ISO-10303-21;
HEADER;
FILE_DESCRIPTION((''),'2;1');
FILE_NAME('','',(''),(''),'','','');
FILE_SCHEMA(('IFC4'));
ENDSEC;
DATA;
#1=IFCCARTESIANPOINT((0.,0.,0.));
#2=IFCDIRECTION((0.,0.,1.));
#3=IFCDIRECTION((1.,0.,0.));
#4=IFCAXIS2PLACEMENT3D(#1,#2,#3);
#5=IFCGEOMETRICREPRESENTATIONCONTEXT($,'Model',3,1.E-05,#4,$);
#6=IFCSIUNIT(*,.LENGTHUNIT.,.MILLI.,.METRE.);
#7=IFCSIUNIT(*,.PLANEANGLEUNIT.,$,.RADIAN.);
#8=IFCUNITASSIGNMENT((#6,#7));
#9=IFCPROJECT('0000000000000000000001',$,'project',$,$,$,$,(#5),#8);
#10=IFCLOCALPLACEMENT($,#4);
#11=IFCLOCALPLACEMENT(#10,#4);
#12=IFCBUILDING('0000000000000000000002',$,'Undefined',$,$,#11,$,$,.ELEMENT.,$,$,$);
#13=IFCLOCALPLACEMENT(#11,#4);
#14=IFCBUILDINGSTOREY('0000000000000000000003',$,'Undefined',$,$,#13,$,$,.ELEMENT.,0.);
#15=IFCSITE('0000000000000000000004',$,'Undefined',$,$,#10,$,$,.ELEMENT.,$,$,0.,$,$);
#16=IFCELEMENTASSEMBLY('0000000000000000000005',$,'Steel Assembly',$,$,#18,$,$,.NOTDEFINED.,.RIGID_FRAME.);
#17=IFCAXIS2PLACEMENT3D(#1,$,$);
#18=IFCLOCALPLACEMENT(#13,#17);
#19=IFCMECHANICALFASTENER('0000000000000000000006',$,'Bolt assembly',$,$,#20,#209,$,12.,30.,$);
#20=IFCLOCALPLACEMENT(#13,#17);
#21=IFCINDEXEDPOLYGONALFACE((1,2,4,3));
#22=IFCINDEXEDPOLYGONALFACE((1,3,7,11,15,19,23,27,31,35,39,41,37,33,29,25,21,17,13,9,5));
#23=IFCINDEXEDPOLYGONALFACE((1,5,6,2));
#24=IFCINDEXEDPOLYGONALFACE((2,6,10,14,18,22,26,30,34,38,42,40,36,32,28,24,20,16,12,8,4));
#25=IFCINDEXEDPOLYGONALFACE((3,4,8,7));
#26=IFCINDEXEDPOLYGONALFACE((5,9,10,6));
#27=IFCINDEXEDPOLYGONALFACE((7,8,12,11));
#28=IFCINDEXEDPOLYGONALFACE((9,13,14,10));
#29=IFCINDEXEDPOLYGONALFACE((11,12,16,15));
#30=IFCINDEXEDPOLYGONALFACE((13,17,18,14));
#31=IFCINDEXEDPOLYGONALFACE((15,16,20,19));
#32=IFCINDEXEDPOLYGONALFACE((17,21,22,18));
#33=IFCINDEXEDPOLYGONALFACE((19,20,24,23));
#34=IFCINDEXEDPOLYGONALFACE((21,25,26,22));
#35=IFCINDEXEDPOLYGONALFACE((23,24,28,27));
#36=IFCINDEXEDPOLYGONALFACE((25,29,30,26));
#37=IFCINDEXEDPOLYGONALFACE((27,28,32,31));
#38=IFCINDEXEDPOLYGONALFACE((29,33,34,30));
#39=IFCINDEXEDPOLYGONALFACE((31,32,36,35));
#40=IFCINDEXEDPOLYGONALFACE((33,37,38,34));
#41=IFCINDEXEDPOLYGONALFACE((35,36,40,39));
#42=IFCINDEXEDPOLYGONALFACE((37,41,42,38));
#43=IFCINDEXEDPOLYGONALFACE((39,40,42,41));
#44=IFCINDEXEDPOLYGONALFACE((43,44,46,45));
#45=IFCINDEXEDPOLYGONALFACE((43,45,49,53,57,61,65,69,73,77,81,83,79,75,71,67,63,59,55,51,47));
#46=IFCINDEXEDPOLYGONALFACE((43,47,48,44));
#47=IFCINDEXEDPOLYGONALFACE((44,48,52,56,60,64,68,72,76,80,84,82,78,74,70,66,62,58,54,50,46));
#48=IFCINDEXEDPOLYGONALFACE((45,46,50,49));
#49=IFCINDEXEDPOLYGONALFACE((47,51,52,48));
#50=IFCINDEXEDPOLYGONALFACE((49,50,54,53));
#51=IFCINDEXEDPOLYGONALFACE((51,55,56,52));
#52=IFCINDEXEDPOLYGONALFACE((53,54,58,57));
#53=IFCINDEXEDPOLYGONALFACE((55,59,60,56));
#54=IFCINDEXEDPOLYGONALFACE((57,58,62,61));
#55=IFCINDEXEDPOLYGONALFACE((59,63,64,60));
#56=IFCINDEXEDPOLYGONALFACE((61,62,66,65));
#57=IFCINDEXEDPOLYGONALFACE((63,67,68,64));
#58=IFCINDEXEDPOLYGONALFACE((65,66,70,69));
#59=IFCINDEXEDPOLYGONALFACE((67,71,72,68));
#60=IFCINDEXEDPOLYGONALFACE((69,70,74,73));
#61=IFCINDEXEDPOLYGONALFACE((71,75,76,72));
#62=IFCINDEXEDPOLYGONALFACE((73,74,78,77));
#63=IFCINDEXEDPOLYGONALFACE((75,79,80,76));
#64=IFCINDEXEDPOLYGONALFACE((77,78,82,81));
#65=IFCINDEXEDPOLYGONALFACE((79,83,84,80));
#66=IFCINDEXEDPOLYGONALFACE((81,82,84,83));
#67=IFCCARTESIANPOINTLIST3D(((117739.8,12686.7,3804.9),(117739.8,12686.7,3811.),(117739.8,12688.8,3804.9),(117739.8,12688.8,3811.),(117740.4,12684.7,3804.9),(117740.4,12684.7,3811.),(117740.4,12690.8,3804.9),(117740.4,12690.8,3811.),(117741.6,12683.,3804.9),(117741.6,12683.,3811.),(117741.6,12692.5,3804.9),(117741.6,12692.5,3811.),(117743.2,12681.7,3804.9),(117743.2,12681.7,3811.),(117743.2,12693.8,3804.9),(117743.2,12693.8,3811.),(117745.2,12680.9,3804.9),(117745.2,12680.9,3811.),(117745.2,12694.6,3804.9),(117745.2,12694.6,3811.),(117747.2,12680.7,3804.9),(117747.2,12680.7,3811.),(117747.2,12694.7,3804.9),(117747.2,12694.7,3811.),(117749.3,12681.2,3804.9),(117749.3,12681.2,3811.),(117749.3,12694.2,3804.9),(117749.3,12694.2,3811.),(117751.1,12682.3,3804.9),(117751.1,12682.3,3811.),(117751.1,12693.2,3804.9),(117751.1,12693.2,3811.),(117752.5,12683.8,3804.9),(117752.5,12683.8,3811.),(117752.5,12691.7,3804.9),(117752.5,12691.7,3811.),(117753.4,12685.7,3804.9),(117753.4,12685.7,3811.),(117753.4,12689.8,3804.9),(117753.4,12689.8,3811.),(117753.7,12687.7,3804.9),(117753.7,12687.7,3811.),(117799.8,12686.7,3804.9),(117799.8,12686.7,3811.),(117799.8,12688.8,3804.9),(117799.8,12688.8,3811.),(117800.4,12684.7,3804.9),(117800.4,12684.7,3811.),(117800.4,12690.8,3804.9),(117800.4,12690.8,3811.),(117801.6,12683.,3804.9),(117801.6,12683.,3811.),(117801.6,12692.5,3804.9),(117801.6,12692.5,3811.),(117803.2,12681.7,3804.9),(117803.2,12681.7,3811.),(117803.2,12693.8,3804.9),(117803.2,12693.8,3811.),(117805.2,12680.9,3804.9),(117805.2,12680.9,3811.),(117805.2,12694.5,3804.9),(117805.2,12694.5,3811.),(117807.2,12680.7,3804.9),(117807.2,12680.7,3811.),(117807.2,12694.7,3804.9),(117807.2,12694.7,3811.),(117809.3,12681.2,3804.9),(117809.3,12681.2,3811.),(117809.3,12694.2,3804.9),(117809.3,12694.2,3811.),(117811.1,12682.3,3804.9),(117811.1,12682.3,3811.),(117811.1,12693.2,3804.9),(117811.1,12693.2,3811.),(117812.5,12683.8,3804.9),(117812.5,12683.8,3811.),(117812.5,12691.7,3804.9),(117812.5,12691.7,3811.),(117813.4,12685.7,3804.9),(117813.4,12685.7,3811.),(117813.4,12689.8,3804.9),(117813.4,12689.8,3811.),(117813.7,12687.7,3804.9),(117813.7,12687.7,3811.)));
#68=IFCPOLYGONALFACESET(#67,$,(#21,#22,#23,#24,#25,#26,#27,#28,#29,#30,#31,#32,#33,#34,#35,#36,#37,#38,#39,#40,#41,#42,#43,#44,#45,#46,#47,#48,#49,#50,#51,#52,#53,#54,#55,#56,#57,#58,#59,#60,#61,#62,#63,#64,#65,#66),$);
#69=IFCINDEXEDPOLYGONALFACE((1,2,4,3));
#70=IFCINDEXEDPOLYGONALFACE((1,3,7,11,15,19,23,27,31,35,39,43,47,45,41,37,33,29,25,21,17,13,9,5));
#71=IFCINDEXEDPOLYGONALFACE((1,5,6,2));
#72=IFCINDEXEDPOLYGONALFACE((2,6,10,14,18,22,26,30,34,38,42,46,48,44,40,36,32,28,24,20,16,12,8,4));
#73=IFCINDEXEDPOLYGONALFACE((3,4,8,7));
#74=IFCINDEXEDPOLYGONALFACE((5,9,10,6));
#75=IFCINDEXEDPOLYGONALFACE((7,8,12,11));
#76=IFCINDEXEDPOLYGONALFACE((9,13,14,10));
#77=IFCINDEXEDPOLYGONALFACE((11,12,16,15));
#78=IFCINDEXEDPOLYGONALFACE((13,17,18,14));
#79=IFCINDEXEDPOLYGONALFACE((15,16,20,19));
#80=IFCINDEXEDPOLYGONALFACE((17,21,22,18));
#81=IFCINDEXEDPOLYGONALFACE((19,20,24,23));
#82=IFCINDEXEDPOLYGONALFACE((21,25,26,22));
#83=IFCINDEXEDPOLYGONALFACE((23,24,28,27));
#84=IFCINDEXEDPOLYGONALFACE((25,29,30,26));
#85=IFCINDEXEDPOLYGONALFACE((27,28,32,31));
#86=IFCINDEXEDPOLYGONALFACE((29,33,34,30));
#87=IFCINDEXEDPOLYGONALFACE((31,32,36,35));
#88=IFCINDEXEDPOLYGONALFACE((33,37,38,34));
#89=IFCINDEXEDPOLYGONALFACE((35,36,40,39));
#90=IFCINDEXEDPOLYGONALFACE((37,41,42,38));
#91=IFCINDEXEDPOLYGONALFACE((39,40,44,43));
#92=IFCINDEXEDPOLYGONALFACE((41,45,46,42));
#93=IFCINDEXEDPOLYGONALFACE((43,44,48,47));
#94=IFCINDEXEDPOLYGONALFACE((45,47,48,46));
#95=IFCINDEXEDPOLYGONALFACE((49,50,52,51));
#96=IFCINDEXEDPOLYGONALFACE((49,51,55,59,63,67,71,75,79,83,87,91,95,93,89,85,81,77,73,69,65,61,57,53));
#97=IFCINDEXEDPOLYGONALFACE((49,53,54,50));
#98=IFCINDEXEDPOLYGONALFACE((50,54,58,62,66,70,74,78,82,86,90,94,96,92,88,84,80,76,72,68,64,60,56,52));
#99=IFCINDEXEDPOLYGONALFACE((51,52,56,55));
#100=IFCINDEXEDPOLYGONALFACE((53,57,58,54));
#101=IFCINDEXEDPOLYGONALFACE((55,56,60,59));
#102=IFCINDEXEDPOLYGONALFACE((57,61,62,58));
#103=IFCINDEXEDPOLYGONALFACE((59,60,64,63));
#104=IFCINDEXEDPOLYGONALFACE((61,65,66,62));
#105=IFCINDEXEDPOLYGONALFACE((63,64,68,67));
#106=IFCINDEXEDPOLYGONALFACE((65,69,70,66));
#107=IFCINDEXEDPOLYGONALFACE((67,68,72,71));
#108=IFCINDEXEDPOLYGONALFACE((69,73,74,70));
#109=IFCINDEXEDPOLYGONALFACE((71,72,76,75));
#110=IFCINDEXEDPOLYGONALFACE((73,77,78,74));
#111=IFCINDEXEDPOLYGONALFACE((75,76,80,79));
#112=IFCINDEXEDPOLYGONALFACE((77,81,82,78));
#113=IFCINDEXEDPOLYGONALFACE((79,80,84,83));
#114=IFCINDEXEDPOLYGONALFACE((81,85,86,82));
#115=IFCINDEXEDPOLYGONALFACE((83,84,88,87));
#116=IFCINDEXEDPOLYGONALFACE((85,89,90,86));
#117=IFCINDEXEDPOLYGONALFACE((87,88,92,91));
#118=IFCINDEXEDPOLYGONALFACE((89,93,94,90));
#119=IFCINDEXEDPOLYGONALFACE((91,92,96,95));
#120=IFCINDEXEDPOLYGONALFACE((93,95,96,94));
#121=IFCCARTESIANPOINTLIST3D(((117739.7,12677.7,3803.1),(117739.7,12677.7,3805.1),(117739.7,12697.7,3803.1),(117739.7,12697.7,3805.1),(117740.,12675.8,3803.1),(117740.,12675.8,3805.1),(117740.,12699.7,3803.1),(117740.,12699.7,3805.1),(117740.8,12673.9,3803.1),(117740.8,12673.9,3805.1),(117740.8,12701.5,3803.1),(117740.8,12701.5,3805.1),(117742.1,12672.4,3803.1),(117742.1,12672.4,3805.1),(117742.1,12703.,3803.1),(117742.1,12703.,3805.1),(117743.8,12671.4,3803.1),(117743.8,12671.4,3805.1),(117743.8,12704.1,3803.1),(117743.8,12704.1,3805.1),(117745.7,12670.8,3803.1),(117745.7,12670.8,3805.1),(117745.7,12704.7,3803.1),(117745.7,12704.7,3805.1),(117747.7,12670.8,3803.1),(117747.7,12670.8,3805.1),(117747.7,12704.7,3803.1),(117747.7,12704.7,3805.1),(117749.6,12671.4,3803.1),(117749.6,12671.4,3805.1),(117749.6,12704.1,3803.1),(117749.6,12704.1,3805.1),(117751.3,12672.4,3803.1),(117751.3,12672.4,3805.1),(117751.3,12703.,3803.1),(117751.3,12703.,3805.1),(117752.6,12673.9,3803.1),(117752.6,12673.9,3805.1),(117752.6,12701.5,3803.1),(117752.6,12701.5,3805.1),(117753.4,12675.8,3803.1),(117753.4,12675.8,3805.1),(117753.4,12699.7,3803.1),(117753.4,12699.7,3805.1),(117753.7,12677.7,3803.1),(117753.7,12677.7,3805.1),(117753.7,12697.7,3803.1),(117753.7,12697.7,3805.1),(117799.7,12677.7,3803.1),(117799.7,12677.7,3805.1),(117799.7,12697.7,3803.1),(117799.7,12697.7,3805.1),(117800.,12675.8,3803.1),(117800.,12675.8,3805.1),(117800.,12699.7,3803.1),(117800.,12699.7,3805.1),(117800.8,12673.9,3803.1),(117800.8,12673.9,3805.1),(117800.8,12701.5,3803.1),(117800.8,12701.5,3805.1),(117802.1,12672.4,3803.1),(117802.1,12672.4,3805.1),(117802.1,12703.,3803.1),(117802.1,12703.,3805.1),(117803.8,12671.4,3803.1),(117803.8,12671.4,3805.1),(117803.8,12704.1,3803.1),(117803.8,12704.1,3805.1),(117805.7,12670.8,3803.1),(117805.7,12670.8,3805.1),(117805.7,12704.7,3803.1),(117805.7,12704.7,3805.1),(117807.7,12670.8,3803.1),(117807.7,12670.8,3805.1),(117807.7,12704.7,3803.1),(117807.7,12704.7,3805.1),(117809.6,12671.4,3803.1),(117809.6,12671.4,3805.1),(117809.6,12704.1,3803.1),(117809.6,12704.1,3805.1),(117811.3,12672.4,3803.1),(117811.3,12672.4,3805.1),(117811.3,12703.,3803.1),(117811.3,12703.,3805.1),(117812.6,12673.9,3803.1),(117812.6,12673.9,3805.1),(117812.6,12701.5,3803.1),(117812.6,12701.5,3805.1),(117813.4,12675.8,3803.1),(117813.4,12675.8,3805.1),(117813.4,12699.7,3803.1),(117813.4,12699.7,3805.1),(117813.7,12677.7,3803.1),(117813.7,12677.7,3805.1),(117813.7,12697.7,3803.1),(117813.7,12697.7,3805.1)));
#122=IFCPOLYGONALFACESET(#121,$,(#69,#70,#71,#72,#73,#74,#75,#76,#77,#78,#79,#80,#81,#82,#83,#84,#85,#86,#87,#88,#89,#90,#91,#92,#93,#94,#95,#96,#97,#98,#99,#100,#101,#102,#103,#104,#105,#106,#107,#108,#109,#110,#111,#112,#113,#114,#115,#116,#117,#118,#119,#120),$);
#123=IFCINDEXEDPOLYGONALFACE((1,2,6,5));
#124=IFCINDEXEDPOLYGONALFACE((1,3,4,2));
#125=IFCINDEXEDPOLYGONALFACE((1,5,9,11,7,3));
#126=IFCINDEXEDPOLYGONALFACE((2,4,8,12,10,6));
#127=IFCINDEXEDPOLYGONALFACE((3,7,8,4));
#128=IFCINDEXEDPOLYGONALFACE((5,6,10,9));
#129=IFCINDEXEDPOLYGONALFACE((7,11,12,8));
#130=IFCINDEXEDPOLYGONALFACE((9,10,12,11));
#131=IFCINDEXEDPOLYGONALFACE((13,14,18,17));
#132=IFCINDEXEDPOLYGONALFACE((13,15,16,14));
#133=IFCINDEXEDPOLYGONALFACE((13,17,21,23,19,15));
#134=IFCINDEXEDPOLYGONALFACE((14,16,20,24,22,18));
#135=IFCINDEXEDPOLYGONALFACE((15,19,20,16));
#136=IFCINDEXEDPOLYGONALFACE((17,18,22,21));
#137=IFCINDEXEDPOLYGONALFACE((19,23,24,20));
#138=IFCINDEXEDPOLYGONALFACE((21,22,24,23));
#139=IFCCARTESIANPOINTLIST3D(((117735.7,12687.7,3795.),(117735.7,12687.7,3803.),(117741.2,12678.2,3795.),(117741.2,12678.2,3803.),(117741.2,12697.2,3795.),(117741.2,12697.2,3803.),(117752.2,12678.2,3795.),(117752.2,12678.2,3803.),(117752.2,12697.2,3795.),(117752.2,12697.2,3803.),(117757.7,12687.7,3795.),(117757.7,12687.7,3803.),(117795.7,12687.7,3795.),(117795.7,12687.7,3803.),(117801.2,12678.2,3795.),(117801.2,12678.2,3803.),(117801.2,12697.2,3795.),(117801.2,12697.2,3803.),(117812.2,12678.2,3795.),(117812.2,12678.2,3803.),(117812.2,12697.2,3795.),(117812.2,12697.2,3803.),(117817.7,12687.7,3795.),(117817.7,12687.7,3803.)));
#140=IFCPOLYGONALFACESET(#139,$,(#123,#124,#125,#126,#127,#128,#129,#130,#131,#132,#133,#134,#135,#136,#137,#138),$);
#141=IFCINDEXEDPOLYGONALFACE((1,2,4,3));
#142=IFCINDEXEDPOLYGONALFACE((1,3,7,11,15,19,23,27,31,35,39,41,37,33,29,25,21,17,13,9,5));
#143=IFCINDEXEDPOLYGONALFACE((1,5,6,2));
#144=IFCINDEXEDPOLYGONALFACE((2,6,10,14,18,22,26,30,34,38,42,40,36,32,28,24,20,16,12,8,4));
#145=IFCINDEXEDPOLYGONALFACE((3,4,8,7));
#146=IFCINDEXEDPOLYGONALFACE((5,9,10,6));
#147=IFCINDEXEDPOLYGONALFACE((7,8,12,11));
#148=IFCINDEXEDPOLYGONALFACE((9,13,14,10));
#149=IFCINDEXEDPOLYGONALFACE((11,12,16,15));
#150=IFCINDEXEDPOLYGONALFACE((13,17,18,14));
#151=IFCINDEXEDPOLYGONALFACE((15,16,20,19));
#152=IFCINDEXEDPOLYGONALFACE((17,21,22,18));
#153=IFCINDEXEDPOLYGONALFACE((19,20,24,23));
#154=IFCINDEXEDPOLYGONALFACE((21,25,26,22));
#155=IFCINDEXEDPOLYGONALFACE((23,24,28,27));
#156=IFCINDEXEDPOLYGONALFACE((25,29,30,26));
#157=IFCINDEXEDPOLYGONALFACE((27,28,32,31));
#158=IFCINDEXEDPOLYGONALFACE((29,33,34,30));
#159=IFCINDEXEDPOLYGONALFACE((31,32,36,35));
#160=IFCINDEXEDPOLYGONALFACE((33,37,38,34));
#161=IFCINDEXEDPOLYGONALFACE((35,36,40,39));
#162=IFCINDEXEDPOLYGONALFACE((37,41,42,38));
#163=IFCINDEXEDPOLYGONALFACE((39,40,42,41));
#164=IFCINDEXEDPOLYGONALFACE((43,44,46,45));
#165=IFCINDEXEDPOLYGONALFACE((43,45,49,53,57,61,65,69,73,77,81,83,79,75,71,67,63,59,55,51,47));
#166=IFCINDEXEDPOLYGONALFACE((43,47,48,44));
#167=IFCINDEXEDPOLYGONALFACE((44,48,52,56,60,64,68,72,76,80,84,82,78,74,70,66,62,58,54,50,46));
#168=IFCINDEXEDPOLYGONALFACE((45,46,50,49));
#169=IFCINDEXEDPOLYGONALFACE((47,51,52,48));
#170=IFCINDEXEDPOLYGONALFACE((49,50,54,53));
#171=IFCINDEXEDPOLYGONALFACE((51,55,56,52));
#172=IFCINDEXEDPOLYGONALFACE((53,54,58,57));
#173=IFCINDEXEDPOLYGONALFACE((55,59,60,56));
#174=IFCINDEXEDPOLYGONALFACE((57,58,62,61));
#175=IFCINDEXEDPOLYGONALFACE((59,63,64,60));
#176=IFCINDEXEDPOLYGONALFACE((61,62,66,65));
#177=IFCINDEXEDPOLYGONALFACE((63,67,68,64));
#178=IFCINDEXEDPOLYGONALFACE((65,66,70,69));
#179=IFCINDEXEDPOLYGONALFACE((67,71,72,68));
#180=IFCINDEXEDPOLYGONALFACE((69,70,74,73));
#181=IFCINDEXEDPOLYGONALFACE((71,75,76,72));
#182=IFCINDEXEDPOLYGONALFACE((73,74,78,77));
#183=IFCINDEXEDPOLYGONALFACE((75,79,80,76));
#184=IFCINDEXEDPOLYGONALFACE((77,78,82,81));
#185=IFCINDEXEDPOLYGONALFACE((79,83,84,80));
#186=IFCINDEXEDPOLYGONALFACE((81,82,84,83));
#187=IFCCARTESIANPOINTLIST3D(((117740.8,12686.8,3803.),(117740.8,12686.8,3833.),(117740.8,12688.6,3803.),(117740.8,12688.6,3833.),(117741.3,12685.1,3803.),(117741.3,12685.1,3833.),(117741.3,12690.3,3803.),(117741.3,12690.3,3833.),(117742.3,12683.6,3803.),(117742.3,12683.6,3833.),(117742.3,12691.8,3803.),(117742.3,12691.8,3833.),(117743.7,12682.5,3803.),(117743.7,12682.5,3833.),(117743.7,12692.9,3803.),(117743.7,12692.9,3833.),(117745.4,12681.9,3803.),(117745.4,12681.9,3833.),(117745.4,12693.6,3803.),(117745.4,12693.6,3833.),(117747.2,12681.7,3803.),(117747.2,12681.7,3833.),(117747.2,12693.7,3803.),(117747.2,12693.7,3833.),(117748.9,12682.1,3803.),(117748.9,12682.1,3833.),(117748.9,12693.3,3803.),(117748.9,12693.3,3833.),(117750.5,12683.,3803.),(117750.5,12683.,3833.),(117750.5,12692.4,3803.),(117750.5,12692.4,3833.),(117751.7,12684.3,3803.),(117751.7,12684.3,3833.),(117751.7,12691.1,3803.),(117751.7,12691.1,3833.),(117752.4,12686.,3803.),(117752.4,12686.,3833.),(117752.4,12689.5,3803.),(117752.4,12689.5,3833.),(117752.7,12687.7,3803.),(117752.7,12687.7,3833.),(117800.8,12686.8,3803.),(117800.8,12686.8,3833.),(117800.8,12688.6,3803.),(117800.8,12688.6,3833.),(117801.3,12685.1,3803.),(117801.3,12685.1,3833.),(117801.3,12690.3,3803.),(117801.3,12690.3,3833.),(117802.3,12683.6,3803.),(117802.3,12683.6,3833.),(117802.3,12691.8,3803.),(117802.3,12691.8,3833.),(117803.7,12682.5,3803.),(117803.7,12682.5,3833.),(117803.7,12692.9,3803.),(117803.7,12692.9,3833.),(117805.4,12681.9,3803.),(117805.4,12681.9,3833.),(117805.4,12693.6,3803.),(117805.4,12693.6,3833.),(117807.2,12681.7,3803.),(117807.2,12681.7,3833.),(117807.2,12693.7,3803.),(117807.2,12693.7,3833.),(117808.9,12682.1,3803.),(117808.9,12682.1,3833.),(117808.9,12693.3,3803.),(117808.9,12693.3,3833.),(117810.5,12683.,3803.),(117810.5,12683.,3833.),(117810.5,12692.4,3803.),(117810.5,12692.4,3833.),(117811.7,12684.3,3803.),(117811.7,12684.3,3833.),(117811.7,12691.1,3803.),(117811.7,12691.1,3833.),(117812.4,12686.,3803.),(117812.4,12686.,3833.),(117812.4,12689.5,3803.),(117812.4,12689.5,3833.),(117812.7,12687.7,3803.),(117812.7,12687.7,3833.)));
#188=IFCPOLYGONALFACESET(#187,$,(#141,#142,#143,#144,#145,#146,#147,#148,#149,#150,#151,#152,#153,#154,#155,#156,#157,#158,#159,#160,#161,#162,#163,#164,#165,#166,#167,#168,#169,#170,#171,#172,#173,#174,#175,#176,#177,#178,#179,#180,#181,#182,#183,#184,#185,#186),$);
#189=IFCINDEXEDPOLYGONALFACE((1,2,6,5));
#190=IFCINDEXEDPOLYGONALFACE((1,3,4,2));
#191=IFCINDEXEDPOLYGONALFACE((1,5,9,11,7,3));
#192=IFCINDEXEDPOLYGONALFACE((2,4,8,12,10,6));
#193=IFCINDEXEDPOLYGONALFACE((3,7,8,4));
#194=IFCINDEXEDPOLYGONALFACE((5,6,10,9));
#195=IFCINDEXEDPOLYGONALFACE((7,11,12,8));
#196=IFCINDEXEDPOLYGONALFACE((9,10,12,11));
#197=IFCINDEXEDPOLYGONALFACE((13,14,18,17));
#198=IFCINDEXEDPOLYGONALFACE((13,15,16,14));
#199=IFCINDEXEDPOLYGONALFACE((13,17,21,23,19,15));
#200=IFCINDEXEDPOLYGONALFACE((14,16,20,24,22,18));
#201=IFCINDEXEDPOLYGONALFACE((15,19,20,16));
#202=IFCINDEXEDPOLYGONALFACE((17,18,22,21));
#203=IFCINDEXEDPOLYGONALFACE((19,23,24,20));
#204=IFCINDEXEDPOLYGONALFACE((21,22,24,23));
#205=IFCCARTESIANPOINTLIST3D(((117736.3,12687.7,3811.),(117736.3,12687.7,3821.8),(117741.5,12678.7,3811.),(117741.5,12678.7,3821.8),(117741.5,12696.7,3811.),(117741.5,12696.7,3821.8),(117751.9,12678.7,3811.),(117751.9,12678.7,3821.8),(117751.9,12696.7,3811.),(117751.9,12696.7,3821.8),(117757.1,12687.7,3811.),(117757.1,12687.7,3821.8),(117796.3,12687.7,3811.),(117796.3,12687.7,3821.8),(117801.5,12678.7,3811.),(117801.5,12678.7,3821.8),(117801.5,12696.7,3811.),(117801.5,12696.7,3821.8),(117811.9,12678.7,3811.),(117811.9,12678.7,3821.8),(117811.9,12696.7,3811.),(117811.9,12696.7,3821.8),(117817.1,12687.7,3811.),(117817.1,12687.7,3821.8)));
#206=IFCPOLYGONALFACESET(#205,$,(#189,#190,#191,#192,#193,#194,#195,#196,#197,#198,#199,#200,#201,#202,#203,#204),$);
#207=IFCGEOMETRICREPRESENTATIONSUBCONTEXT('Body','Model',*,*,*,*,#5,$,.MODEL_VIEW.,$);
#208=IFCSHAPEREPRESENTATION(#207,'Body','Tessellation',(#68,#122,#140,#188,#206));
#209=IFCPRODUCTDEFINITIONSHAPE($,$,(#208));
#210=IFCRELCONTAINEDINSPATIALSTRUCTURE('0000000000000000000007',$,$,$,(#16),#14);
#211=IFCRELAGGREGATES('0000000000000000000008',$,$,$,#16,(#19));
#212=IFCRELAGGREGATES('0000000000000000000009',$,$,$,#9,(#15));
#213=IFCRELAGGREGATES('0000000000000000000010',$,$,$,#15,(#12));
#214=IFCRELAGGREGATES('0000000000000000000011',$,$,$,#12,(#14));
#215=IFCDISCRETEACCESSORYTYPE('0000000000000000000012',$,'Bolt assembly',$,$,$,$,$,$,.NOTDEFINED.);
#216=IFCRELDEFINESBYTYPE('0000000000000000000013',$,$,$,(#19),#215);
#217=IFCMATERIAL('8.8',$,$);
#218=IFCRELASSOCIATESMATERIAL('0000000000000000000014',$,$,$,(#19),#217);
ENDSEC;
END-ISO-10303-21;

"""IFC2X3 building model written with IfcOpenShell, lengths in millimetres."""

from ifc_helpers import new_model, si_unit, frame, frame_2d, origin_with_axes, origin_2d_with_axis, place, context, subcontext, project, spatial, polyline, circle_curve, parameter, trimmed, segment, composite_curve, circle, outline, extrude, source, transform, mapped, material, type_object, element, aggregate, save


model = new_model("IFC2X3")

# Units and contexts
model_context = context("Model", 3, precision=1e-05, world=origin_with_axes())
body_context = subcontext(model_context, "Body", "Model", "MODEL_VIEW")
ifc_project = project(units=[si_unit("LENGTHUNIT", "METRE", prefix="MILLI"), si_unit("PLANEANGLEUNIT", "RADIAN")], contexts=[model_context])

# Site, building, storey
site_placement = place(None, origin_with_axes())
site = spatial("IfcSite", under=ifc_project, at=site_placement, Name="Undefined", CompositionType="ELEMENT", RefElevation=0.0)
building_placement = place(site_placement, origin_with_axes())
building = spatial("IfcBuilding", under=site, at=building_placement, Name="Undefined", CompositionType="ELEMENT")
storey_placement = place(building_placement, origin_with_axes())
storey = spatial("IfcBuildingStorey", under=building, at=storey_placement, Name="Undefined", CompositionType="ELEMENT", Elevation=0.0)

# Element assembly
assembly_1_placement = place(storey_placement, origin_with_axes())
assembly_1 = element("IfcElementAssembly", 1, at=assembly_1_placement, inside=storey, Name="Steel Assembly", AssemblyPlace="NOTDEFINED", PredefinedType="RIGID_FRAME")

# Shared definitions
ifc_material_1 = material(Name="8.8")
discrete_accessory_type_1 = type_object("IfcDiscreteAccessoryType", Name="Bolt assembly")

# Mechanical fastener
shared_shape_1 = source(origin_with_axes(), body_context, "Body", "SweptSolid", [
    extrude(circle(Radius=7.0, at=origin_2d_with_axis()), frame((0.0, -3.1, 0.0), z_axis=(0.0, 1.0, 0.0), x_axis=(1.0, 0.0, 0.0)), (0.0, 0.0, 1.0), 6.1),
    extrude(outline(composite_curve([segment(polyline([(7.0, 10.0), (7.0, -10.0)]), True, "CONTINUOUS"), segment(trimmed(circle_curve(frame_2d((0.0, -10.0), x_axis=(1.0, 0.0)), 7.0), [parameter(0.0)], [parameter(3.1416)], False, "PARAMETER"), True, "CONTINUOUS"), segment(polyline([(-7.0, -10.0), (-7.0, 10.0)]), True, "CONTINUOUS"), segment(trimmed(circle_curve(frame_2d((0.0, 10.0), x_axis=(-1.0, 0.0)), 7.0), [parameter(0.0)], [parameter(3.1416)], False, "PARAMETER"), True, "DISCONTINUOUS")], self_intersect=False)), frame((0.0, -4.9, 0.0), z_axis=(0.0, 1.0, 0.0), x_axis=(1.0, 0.0, 0.0)), (0.0, 0.0, 1.0), 2.0),
    extrude(outline(polyline([(11.0, 0.0), (5.5, 9.5), (-5.5, 9.5), (-11.0, 0.0), (-5.5, -9.5), (5.5, -9.5), (11.0, 0.0)])), frame((0.0, -13.0, 0.0), z_axis=(0.0, 1.0, 0.0), x_axis=(1.0, 0.0, 0.0)), (0.0, 0.0, 1.0), 8.0),
    extrude(circle(Radius=6.0, at=origin_2d_with_axis()), frame((0.0, -5.0, 0.0), z_axis=(0.0, 1.0, 0.0), x_axis=(1.0, 0.0, 0.0)), (0.0, 0.0, 1.0), 30.0),
    extrude(outline(polyline([(10.4, 0.0), (5.2, 9.0), (-5.2, 9.0), (-10.4, 0.0), (-5.2, -9.0), (5.2, -9.0), (10.4, 0.0)])), frame((0.0, 3.0, 0.0), z_axis=(0.0, 1.0, 0.0), x_axis=(1.0, 0.0, 0.0)), (0.0, 0.0, 1.0), 10.8),
])
mechanical_fastener_1_placement = place(assembly_1_placement, frame((117701.7, 12732.7, 3808.0), z_axis=(-0.000045, -1.0, 0.0), x_axis=(1.0, -0.000045, 0.0)))
mechanical_fastener_1 = element("IfcMechanicalFastener", 2, at=mechanical_fastener_1_placement, type_object=discrete_accessory_type_1, material=ifc_material_1, Name="Bolt assembly", NominalDiameter=12.0, NominalLength=30.0, context=body_context, shape_type="MappedRepresentation", body=[
    mapped(shared_shape_1, transform((45.0, 0.0, 45.0))),
    mapped(shared_shape_1, transform((105.0, 0.0, 45.0))),
])
aggregate(assembly_1, [mechanical_fastener_1])

save(model, "model.ifc")
